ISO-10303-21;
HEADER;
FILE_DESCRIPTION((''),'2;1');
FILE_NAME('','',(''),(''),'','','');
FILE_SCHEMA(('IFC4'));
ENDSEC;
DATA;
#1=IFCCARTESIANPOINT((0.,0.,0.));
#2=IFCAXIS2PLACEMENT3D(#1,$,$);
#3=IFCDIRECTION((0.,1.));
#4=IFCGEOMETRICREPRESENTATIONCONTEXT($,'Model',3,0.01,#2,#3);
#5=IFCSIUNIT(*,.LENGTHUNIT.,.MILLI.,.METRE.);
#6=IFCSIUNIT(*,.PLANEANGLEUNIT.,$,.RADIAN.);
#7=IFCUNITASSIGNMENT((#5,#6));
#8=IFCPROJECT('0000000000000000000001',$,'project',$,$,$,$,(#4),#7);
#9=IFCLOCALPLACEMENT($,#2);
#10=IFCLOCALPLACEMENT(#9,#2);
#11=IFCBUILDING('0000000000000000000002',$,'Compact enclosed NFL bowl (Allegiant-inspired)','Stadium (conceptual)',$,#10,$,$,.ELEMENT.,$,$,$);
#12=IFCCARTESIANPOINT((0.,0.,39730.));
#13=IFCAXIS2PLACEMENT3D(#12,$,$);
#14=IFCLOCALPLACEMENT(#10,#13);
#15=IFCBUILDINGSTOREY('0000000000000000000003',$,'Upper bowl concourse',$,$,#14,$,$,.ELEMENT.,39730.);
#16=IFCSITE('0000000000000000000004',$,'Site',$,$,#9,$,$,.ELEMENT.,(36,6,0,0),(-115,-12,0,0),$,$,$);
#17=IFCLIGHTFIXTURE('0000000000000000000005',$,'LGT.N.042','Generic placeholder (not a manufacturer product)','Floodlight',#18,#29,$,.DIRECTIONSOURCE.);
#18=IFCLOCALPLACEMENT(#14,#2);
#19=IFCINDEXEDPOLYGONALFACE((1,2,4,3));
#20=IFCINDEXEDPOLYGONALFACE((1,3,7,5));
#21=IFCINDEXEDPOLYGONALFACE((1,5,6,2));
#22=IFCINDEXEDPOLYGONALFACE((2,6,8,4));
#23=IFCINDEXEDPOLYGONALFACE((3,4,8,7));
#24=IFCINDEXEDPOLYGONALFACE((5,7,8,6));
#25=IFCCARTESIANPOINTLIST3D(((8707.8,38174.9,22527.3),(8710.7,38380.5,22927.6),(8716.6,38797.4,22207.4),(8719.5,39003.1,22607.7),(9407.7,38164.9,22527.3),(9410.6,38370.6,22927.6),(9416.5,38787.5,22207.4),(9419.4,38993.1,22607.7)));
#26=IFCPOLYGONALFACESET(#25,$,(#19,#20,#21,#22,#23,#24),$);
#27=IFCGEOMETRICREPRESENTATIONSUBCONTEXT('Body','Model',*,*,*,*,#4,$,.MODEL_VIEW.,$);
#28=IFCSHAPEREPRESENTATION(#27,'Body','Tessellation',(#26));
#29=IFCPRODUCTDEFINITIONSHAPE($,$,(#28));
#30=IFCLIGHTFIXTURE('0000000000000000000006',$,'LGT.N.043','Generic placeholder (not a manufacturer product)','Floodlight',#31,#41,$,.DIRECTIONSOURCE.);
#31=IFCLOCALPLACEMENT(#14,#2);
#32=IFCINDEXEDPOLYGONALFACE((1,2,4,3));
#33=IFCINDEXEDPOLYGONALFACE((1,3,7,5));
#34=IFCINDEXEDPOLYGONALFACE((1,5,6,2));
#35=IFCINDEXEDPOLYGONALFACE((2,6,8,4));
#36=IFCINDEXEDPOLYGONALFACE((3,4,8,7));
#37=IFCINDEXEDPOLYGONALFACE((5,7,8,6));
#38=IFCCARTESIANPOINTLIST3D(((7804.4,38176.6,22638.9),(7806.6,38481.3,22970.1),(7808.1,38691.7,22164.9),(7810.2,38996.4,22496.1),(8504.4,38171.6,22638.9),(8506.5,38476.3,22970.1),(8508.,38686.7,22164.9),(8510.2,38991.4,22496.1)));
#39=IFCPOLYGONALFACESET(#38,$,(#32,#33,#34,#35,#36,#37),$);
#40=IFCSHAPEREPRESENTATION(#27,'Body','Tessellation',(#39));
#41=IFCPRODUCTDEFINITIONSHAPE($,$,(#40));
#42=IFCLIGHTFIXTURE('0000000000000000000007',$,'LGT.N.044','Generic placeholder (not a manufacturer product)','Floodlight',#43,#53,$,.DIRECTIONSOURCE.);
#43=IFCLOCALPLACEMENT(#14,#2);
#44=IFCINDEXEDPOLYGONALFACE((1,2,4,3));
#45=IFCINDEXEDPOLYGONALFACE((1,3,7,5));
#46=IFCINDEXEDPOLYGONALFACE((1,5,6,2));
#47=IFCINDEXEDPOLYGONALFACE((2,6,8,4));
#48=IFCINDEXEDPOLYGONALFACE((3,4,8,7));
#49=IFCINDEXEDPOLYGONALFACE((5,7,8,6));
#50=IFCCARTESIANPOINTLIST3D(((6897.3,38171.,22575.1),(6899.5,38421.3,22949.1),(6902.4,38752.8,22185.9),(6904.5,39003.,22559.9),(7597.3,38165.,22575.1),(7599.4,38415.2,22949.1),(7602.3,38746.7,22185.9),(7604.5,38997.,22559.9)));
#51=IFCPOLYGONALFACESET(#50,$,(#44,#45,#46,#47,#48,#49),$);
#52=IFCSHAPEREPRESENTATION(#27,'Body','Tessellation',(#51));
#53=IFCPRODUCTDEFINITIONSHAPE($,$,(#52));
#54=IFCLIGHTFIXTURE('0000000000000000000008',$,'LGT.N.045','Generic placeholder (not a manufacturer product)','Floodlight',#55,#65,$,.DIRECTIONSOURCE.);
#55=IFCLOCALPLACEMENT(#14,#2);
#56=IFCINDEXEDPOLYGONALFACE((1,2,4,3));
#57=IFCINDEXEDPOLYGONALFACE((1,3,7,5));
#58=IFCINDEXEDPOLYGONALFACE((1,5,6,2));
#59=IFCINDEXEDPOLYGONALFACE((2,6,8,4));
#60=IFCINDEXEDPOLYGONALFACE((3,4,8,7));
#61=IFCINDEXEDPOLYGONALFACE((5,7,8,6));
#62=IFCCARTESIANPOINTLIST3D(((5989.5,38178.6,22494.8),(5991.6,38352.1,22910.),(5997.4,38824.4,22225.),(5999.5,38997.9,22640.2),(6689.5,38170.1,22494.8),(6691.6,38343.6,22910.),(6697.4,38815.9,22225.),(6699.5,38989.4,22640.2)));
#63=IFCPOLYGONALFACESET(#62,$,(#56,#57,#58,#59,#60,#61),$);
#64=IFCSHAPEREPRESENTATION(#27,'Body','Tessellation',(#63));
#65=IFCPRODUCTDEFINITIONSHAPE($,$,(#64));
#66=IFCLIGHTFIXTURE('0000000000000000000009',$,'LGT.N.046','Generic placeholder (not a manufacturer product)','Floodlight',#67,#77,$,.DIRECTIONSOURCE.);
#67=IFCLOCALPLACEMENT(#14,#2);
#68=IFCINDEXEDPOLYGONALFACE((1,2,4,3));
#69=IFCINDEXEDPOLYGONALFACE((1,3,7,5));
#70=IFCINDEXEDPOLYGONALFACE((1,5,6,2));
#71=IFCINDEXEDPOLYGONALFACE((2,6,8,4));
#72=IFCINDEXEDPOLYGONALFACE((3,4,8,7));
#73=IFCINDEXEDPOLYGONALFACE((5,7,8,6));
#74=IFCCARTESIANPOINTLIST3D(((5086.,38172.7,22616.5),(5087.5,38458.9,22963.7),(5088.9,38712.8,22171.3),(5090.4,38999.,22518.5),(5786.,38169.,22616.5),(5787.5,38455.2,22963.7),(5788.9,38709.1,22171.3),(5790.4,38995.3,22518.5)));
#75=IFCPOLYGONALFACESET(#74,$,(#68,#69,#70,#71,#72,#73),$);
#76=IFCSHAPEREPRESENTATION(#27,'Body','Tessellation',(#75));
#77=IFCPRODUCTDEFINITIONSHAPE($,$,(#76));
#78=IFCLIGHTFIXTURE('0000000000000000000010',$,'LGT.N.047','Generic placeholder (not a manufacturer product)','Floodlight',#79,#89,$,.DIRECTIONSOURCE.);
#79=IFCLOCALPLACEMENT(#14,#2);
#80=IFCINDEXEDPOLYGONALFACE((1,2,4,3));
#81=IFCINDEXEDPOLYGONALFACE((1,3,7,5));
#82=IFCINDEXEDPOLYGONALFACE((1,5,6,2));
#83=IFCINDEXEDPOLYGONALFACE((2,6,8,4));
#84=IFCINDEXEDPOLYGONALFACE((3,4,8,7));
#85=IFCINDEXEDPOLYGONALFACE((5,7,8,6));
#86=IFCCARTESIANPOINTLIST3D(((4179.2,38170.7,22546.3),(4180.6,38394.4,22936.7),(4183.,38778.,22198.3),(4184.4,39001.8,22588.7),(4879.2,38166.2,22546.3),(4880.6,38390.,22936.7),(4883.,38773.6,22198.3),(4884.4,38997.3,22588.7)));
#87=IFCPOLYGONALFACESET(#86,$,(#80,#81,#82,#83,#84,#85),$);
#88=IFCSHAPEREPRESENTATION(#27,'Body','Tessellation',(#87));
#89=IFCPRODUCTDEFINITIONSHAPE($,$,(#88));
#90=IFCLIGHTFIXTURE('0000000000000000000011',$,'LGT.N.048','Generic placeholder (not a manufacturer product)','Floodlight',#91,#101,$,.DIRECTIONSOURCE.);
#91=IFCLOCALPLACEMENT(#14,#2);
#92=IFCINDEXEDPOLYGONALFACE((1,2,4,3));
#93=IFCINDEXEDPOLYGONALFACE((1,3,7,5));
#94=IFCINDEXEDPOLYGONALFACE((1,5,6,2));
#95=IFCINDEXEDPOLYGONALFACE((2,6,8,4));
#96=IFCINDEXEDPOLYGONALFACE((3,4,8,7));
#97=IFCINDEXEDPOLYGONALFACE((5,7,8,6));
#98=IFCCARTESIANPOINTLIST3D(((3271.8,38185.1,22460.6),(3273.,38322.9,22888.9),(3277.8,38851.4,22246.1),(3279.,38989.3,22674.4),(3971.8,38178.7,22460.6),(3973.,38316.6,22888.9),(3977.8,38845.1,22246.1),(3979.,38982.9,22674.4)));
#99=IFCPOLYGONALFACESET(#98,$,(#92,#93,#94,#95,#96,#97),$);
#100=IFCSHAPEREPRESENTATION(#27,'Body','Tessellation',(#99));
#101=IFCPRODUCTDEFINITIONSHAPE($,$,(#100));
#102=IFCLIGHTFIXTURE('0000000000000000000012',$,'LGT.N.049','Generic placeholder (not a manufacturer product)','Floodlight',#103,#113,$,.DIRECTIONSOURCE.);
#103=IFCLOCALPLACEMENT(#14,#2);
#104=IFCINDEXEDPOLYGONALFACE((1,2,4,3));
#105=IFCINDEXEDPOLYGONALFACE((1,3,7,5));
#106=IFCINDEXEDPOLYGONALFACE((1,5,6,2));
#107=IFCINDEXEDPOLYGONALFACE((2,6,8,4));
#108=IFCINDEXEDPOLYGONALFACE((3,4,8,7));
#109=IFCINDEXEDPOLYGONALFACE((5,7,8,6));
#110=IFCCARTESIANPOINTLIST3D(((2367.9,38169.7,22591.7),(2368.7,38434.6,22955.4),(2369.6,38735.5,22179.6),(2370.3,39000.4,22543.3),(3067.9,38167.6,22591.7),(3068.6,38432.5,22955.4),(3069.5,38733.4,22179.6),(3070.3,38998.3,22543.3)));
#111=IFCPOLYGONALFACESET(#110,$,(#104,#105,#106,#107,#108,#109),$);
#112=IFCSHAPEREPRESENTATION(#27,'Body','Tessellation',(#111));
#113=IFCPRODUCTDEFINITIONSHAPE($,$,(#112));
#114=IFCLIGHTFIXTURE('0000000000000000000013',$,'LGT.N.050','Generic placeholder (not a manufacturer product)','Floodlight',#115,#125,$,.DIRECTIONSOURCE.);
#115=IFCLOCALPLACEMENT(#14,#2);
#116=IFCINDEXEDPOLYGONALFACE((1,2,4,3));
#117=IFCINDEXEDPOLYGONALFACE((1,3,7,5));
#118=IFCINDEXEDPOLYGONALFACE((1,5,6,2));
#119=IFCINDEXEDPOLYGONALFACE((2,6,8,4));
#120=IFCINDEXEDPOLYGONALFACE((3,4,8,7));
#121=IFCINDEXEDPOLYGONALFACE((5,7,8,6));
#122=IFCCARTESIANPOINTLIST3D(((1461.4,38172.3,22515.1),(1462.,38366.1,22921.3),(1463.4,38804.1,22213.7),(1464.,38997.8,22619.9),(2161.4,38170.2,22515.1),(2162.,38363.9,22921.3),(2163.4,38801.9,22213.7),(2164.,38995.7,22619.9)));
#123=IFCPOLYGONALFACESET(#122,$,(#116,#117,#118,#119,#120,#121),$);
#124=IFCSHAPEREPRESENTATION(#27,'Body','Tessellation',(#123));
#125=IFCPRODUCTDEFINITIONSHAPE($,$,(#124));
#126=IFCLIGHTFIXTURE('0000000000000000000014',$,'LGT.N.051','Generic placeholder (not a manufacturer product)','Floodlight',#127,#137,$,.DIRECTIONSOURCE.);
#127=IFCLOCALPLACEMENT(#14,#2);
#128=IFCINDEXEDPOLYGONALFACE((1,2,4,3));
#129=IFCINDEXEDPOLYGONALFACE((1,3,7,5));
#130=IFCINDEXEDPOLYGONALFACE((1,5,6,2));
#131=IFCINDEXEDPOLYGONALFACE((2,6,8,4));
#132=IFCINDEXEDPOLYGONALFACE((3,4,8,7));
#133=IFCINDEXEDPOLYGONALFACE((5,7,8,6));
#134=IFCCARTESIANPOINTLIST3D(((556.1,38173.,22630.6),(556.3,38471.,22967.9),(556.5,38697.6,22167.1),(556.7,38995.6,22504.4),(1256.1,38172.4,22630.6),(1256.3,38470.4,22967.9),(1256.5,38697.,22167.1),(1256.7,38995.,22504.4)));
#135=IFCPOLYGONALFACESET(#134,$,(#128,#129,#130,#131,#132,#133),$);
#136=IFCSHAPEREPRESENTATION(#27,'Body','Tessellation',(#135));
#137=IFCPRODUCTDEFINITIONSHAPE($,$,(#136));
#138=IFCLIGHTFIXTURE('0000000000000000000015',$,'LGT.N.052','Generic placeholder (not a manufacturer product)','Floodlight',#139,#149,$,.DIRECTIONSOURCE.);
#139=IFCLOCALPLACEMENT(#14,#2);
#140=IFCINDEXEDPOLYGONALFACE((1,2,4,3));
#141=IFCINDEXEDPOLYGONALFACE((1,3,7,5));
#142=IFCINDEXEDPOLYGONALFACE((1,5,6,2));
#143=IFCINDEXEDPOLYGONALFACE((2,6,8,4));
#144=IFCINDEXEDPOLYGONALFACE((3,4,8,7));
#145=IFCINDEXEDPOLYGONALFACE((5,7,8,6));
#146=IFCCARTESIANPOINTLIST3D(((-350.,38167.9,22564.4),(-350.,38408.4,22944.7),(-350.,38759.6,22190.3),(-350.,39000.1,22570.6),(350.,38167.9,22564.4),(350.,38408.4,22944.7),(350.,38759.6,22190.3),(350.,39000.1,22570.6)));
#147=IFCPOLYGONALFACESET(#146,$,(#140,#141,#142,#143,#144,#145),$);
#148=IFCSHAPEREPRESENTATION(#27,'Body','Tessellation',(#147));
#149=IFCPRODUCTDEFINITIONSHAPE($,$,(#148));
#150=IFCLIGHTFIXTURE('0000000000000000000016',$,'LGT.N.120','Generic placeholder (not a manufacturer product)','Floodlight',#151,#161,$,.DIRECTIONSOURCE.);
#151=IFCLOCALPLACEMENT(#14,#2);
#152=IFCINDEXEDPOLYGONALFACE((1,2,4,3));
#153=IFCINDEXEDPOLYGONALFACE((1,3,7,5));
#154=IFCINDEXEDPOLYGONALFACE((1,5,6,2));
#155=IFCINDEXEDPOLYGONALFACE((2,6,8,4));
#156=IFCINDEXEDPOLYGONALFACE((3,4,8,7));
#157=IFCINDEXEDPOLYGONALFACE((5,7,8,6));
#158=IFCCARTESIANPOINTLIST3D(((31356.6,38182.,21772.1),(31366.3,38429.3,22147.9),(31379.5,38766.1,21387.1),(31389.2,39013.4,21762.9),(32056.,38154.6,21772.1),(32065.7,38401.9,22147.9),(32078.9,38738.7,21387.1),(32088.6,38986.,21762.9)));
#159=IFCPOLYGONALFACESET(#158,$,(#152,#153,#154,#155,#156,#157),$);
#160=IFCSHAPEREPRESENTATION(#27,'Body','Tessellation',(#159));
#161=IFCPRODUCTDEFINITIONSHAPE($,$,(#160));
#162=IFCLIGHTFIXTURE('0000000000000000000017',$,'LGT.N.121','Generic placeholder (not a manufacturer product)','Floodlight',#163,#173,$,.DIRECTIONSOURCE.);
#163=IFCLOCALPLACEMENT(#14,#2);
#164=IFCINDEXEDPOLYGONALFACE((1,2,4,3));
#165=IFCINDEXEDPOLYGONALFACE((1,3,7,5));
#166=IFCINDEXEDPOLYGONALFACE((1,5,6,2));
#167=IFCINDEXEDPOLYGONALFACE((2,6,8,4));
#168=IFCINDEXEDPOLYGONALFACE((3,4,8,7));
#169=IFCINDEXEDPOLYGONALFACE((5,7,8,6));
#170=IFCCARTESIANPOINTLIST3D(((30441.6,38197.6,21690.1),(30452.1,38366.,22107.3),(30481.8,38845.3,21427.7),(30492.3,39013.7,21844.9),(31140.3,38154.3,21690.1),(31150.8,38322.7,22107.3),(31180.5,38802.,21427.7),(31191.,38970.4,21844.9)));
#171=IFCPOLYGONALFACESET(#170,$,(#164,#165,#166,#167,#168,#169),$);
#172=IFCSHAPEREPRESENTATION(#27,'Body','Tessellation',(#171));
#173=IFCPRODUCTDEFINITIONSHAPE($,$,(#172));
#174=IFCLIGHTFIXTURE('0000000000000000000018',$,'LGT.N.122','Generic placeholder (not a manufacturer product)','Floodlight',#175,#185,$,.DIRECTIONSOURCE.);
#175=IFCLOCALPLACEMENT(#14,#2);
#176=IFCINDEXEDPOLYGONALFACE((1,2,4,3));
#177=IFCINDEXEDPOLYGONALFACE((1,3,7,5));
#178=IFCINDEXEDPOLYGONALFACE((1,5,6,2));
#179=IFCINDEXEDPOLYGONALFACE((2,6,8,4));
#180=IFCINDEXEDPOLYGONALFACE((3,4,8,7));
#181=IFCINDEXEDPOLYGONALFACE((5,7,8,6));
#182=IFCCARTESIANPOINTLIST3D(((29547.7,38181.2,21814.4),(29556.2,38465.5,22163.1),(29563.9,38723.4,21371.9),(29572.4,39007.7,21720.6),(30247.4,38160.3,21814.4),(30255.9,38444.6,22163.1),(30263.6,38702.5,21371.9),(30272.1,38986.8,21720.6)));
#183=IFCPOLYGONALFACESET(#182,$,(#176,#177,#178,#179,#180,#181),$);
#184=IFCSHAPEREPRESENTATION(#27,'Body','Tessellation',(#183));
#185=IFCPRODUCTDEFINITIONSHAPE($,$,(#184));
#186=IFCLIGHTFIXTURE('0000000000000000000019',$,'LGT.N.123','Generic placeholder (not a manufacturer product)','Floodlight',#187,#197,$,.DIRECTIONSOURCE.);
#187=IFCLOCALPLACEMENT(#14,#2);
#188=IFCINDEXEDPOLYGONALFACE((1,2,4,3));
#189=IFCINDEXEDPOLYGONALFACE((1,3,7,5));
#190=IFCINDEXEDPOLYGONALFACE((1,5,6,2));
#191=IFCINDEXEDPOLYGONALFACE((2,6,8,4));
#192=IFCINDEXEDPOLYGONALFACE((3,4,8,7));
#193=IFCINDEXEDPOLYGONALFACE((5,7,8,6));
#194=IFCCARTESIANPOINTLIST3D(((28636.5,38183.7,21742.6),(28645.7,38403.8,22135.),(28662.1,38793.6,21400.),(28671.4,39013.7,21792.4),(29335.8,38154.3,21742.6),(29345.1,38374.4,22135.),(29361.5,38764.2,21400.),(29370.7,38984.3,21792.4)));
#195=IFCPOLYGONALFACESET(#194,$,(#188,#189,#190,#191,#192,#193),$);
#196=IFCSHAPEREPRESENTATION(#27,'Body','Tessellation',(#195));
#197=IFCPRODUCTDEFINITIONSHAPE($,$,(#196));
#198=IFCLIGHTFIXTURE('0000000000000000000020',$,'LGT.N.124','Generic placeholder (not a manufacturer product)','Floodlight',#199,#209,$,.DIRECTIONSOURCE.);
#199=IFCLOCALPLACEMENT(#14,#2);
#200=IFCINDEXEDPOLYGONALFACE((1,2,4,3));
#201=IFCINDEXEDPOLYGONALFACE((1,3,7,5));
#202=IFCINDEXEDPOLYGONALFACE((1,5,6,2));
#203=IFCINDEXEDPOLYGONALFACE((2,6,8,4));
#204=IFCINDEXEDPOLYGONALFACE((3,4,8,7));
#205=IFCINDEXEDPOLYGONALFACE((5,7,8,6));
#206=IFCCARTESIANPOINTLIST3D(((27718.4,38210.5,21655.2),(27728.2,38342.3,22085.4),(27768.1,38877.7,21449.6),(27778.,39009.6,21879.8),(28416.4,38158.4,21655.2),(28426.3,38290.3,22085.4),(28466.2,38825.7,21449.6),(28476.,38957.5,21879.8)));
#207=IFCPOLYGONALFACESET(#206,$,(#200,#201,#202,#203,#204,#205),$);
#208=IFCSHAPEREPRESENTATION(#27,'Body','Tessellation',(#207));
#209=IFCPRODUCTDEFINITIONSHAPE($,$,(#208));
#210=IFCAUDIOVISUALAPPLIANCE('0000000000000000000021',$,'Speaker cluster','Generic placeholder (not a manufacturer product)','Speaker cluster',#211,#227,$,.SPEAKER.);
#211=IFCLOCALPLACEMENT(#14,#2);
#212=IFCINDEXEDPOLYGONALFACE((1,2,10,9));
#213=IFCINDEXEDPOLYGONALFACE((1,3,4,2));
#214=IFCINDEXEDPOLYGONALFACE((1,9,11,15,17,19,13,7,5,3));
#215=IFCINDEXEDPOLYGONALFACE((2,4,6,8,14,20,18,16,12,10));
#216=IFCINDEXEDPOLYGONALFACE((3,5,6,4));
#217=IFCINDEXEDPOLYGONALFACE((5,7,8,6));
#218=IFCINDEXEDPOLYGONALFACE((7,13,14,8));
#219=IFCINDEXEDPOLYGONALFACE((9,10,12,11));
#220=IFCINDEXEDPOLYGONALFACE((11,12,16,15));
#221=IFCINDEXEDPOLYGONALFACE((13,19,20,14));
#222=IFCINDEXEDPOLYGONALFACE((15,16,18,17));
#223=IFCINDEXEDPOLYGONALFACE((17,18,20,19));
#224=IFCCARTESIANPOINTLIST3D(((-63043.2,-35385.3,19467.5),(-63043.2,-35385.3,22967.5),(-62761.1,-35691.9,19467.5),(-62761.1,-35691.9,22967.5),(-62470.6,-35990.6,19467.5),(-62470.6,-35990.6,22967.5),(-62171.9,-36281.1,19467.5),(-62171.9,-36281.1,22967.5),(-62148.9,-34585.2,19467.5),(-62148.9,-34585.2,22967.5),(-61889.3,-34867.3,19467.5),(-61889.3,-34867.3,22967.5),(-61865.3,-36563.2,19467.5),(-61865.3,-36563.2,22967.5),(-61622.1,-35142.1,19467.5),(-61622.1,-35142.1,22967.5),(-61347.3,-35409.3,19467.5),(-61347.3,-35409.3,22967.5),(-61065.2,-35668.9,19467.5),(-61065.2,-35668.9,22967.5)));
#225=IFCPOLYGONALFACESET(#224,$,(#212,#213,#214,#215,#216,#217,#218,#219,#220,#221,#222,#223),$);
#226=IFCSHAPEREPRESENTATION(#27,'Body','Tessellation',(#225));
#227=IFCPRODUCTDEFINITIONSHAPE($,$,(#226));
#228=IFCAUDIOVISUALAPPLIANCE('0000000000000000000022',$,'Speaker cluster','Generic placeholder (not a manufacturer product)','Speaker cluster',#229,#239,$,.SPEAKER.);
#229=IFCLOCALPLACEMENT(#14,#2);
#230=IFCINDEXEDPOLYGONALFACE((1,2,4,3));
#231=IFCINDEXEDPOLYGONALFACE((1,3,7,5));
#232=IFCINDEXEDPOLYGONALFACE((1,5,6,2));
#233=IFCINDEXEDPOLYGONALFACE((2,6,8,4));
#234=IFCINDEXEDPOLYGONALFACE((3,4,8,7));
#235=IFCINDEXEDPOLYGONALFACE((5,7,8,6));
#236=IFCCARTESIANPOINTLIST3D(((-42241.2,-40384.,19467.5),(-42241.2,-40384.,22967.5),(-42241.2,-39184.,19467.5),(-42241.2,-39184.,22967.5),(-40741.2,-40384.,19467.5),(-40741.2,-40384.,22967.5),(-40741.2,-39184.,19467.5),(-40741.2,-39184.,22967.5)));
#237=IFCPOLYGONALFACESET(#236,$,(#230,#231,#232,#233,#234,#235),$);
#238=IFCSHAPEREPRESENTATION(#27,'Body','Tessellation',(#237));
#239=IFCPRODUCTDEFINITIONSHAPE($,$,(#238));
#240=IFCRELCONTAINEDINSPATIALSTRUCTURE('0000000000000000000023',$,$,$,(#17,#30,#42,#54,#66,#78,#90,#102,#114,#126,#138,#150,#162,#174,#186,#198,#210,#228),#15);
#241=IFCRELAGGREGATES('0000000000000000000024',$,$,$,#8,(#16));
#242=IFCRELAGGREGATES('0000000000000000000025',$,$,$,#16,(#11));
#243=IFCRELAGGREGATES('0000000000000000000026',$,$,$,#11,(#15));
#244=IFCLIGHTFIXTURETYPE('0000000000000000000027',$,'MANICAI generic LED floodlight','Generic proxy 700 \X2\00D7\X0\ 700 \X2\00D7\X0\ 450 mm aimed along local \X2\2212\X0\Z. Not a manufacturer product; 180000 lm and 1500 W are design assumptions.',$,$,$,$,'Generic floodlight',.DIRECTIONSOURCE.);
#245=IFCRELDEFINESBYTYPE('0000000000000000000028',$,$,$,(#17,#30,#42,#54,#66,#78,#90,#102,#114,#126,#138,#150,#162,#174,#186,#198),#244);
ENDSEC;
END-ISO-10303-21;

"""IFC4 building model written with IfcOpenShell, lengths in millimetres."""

from ifc_helpers import new_model, si_unit, direction, frame, origin, place, context, subcontext, project, spatial, line, arc, indexed_curve, rectangle, outline, extrude, source, transform, mapped, type_object, type_shapes, element, save


model = new_model("IFC4")

# Units and contexts
model_context = context("Model", 3, precision=0.01, world=origin(), true_north=direction((0.0, 1.0)))
body_context = subcontext(model_context, "Body", "Model", "MODEL_VIEW")
ifc_project = project(units=[si_unit("LENGTHUNIT", "METRE", prefix="MILLI"), si_unit("PLANEANGLEUNIT", "RADIAN")], contexts=[model_context])

# Site, building, storey
site_placement = place(None, origin())
site = spatial("IfcSite", under=ifc_project, at=site_placement, Name="Site", CompositionType="ELEMENT", RefLatitude=(36, 6, 0, 0), RefLongitude=(-115, -12, 0, 0))
building_placement = place(site_placement, origin())
building = spatial("IfcBuilding", under=site, at=building_placement, Name="Compact enclosed NFL bowl (Allegiant-inspired)", Description="Stadium (conceptual)", CompositionType="ELEMENT")
storey_placement = place(building_placement, frame((0.0, 0.0, 39730.0)))
storey = spatial("IfcBuildingStorey", under=building, at=storey_placement, Name="Upper bowl concourse", CompositionType="ELEMENT", Elevation=39730.0)

# Shared definitions
placement = place(storey_placement, frame((0.0, 0.0, -39730.0)))

# Light fixtures
light_fixture_type = type_object("IfcLightFixtureType", Name="MANICAI generic LED floodlight", Description="Generic proxy 700 × 700 × 450 mm aimed along local −Z. Not a manufacturer product; 180000 lm and 1500 W are design assumptions.", ElementType="Generic floodlight", PredefinedType="DIRECTIONSOURCE")
shared_shape = source(origin(), body_context, "Body", "SweptSolid", [
    extrude(rectangle(XDim=700.0, YDim=700.0), frame((0.0, 0.0, -225.0)), (0.0, 0.0, 1.0), 450.0),
])
type_shapes(light_fixture_type, [shared_shape])
for number, where, z_axis, x_axis, name in (
    (1, (9063.6, 38584.0, 22567.5), (0.00647, 0.456955, 0.889466), (-0.9999, 0.014158, 0.0), "LGT.N.042"),
    (2, (8157.3, 38584.0, 22567.5), (0.004818, 0.677106, 0.73587), (-0.999975, 0.007115, 0.0), "LGT.N.043"),
    (3, (7250.9, 38584.0, 22567.5), (0.004837, 0.55602, 0.831155), (-0.999962, 0.008699, 0.0), "LGT.N.044"),
    (4, (6344.5, 38584.0, 22567.5), (0.004698, 0.385503, 0.922694), (-0.999926, 0.012187, 0.0), "LGT.N.045"),
    (5, (5438.2, 38584.0, 22567.5), (0.003368, 0.636014, 0.77167), (-0.999986, 0.005296, 0.0), "LGT.N.046"),
    (6, (4531.8, 38584.0, 22567.5), (0.003156, 0.497186, 0.867638), (-0.99998, 0.006347, 0.0), "LGT.N.047"),
    (7, (3625.4, 38584.0, 22567.5), (0.00277, 0.306383, 0.951904), (-0.999959, 0.00904, 0.0), "LGT.N.048"),
    (8, (2719.1, 38584.0, 22567.5), (0.001764, 0.588696, 0.808353), (-0.999996, 0.002997, 0.0), "LGT.N.049"),
    (9, (1812.7, 38584.0, 22567.5), (0.001313, 0.430599, 0.902543), (-0.999995, 0.003049, 0.0), "LGT.N.050"),
    (10, (906.4, 38584.0, 22567.5), (0.000545, 0.662104, 0.749412), (-1.0, 0.000823, 0.0), "LGT.N.051"),
    (11, (0.0, 38584.0, 22567.5), (0.0, 0.534445, 0.845203), (-1.0, 0.0, 0.0), "LGT.N.052"),
    (12, (31722.6, 38584.0, 21767.5), (0.02154, 0.549597, 0.835152), (-0.999233, 0.039163, 0.0), "LGT.N.120"),
    (13, (30816.3, 38584.0, 21767.5), (0.023227, 0.374199, 0.927058), (-0.998079, 0.061953, 0.0), "LGT.N.121"),
    (14, (29909.9, 38584.0, 21767.5), (0.018844, 0.631801, 0.774902), (-0.999556, 0.029813, 0.0), "LGT.N.122"),
    (15, (29003.6, 38584.0, 21767.5), (0.020562, 0.489093, 0.871989), (-0.999117, 0.042005, 0.0), "LGT.N.123"),
    (16, (28097.2, 38584.0, 21767.5), (0.021836, 0.292935, 0.955883), (-0.997233, 0.074337, 0.0), "LGT.N.124"),
):
    element("IfcLightFixture", number, at=place(storey_placement, frame(where, z_axis=z_axis, x_axis=x_axis)), inside=storey, type_object=light_fixture_type, Name=name, Description="Generic placeholder (not a manufacturer product)", ObjectType="Floodlight", PredefinedType="DIRECTIONSOURCE", context=body_context, shape_type="MappedRepresentation", body=[
        mapped(shared_shape, transform((0.0, 0.0, 0.0))),
    ])

# Audio visual appliances
element("IfcAudioVisualAppliance", 17, at=placement, inside=storey, Name="Speaker cluster", Description="Generic placeholder (not a manufacturer product)", ObjectType="Speaker cluster", PredefinedType="SPEAKER", context=body_context, shape_type="SweptSolid", body=[
    extrude(outline(indexed_curve([(-62148.9, -34585.2), (-61622.1, -35142.1), (-61065.2, -35668.9), (-61865.3, -36563.2), (-62470.6, -35990.6), (-63043.2, -35385.3)], segments=[arc(1, 2, 3), line(3, 4), arc(4, 5, 6), line(6, 1)], self_intersect=False)), frame((0.0, 0.0, 59197.5)), (0.0, 0.0, 1.0), 3500.0),
])
element("IfcAudioVisualAppliance", 18, at=placement, inside=storey, Name="Speaker cluster", Description="Generic placeholder (not a manufacturer product)", ObjectType="Speaker cluster", PredefinedType="SPEAKER", context=body_context, shape_type="SweptSolid", body=[
    extrude(outline(indexed_curve([(-42241.2, -39184.0), (-40741.2, -39184.0), (-40741.2, -40384.0), (-42241.2, -40384.0)], segments=[line(1, 2), line(2, 3), line(3, 4), line(4, 1)], self_intersect=False)), frame((0.0, 0.0, 59197.5)), (0.0, 0.0, 1.0), 3500.0),
])

save(model, "model.ifc")
